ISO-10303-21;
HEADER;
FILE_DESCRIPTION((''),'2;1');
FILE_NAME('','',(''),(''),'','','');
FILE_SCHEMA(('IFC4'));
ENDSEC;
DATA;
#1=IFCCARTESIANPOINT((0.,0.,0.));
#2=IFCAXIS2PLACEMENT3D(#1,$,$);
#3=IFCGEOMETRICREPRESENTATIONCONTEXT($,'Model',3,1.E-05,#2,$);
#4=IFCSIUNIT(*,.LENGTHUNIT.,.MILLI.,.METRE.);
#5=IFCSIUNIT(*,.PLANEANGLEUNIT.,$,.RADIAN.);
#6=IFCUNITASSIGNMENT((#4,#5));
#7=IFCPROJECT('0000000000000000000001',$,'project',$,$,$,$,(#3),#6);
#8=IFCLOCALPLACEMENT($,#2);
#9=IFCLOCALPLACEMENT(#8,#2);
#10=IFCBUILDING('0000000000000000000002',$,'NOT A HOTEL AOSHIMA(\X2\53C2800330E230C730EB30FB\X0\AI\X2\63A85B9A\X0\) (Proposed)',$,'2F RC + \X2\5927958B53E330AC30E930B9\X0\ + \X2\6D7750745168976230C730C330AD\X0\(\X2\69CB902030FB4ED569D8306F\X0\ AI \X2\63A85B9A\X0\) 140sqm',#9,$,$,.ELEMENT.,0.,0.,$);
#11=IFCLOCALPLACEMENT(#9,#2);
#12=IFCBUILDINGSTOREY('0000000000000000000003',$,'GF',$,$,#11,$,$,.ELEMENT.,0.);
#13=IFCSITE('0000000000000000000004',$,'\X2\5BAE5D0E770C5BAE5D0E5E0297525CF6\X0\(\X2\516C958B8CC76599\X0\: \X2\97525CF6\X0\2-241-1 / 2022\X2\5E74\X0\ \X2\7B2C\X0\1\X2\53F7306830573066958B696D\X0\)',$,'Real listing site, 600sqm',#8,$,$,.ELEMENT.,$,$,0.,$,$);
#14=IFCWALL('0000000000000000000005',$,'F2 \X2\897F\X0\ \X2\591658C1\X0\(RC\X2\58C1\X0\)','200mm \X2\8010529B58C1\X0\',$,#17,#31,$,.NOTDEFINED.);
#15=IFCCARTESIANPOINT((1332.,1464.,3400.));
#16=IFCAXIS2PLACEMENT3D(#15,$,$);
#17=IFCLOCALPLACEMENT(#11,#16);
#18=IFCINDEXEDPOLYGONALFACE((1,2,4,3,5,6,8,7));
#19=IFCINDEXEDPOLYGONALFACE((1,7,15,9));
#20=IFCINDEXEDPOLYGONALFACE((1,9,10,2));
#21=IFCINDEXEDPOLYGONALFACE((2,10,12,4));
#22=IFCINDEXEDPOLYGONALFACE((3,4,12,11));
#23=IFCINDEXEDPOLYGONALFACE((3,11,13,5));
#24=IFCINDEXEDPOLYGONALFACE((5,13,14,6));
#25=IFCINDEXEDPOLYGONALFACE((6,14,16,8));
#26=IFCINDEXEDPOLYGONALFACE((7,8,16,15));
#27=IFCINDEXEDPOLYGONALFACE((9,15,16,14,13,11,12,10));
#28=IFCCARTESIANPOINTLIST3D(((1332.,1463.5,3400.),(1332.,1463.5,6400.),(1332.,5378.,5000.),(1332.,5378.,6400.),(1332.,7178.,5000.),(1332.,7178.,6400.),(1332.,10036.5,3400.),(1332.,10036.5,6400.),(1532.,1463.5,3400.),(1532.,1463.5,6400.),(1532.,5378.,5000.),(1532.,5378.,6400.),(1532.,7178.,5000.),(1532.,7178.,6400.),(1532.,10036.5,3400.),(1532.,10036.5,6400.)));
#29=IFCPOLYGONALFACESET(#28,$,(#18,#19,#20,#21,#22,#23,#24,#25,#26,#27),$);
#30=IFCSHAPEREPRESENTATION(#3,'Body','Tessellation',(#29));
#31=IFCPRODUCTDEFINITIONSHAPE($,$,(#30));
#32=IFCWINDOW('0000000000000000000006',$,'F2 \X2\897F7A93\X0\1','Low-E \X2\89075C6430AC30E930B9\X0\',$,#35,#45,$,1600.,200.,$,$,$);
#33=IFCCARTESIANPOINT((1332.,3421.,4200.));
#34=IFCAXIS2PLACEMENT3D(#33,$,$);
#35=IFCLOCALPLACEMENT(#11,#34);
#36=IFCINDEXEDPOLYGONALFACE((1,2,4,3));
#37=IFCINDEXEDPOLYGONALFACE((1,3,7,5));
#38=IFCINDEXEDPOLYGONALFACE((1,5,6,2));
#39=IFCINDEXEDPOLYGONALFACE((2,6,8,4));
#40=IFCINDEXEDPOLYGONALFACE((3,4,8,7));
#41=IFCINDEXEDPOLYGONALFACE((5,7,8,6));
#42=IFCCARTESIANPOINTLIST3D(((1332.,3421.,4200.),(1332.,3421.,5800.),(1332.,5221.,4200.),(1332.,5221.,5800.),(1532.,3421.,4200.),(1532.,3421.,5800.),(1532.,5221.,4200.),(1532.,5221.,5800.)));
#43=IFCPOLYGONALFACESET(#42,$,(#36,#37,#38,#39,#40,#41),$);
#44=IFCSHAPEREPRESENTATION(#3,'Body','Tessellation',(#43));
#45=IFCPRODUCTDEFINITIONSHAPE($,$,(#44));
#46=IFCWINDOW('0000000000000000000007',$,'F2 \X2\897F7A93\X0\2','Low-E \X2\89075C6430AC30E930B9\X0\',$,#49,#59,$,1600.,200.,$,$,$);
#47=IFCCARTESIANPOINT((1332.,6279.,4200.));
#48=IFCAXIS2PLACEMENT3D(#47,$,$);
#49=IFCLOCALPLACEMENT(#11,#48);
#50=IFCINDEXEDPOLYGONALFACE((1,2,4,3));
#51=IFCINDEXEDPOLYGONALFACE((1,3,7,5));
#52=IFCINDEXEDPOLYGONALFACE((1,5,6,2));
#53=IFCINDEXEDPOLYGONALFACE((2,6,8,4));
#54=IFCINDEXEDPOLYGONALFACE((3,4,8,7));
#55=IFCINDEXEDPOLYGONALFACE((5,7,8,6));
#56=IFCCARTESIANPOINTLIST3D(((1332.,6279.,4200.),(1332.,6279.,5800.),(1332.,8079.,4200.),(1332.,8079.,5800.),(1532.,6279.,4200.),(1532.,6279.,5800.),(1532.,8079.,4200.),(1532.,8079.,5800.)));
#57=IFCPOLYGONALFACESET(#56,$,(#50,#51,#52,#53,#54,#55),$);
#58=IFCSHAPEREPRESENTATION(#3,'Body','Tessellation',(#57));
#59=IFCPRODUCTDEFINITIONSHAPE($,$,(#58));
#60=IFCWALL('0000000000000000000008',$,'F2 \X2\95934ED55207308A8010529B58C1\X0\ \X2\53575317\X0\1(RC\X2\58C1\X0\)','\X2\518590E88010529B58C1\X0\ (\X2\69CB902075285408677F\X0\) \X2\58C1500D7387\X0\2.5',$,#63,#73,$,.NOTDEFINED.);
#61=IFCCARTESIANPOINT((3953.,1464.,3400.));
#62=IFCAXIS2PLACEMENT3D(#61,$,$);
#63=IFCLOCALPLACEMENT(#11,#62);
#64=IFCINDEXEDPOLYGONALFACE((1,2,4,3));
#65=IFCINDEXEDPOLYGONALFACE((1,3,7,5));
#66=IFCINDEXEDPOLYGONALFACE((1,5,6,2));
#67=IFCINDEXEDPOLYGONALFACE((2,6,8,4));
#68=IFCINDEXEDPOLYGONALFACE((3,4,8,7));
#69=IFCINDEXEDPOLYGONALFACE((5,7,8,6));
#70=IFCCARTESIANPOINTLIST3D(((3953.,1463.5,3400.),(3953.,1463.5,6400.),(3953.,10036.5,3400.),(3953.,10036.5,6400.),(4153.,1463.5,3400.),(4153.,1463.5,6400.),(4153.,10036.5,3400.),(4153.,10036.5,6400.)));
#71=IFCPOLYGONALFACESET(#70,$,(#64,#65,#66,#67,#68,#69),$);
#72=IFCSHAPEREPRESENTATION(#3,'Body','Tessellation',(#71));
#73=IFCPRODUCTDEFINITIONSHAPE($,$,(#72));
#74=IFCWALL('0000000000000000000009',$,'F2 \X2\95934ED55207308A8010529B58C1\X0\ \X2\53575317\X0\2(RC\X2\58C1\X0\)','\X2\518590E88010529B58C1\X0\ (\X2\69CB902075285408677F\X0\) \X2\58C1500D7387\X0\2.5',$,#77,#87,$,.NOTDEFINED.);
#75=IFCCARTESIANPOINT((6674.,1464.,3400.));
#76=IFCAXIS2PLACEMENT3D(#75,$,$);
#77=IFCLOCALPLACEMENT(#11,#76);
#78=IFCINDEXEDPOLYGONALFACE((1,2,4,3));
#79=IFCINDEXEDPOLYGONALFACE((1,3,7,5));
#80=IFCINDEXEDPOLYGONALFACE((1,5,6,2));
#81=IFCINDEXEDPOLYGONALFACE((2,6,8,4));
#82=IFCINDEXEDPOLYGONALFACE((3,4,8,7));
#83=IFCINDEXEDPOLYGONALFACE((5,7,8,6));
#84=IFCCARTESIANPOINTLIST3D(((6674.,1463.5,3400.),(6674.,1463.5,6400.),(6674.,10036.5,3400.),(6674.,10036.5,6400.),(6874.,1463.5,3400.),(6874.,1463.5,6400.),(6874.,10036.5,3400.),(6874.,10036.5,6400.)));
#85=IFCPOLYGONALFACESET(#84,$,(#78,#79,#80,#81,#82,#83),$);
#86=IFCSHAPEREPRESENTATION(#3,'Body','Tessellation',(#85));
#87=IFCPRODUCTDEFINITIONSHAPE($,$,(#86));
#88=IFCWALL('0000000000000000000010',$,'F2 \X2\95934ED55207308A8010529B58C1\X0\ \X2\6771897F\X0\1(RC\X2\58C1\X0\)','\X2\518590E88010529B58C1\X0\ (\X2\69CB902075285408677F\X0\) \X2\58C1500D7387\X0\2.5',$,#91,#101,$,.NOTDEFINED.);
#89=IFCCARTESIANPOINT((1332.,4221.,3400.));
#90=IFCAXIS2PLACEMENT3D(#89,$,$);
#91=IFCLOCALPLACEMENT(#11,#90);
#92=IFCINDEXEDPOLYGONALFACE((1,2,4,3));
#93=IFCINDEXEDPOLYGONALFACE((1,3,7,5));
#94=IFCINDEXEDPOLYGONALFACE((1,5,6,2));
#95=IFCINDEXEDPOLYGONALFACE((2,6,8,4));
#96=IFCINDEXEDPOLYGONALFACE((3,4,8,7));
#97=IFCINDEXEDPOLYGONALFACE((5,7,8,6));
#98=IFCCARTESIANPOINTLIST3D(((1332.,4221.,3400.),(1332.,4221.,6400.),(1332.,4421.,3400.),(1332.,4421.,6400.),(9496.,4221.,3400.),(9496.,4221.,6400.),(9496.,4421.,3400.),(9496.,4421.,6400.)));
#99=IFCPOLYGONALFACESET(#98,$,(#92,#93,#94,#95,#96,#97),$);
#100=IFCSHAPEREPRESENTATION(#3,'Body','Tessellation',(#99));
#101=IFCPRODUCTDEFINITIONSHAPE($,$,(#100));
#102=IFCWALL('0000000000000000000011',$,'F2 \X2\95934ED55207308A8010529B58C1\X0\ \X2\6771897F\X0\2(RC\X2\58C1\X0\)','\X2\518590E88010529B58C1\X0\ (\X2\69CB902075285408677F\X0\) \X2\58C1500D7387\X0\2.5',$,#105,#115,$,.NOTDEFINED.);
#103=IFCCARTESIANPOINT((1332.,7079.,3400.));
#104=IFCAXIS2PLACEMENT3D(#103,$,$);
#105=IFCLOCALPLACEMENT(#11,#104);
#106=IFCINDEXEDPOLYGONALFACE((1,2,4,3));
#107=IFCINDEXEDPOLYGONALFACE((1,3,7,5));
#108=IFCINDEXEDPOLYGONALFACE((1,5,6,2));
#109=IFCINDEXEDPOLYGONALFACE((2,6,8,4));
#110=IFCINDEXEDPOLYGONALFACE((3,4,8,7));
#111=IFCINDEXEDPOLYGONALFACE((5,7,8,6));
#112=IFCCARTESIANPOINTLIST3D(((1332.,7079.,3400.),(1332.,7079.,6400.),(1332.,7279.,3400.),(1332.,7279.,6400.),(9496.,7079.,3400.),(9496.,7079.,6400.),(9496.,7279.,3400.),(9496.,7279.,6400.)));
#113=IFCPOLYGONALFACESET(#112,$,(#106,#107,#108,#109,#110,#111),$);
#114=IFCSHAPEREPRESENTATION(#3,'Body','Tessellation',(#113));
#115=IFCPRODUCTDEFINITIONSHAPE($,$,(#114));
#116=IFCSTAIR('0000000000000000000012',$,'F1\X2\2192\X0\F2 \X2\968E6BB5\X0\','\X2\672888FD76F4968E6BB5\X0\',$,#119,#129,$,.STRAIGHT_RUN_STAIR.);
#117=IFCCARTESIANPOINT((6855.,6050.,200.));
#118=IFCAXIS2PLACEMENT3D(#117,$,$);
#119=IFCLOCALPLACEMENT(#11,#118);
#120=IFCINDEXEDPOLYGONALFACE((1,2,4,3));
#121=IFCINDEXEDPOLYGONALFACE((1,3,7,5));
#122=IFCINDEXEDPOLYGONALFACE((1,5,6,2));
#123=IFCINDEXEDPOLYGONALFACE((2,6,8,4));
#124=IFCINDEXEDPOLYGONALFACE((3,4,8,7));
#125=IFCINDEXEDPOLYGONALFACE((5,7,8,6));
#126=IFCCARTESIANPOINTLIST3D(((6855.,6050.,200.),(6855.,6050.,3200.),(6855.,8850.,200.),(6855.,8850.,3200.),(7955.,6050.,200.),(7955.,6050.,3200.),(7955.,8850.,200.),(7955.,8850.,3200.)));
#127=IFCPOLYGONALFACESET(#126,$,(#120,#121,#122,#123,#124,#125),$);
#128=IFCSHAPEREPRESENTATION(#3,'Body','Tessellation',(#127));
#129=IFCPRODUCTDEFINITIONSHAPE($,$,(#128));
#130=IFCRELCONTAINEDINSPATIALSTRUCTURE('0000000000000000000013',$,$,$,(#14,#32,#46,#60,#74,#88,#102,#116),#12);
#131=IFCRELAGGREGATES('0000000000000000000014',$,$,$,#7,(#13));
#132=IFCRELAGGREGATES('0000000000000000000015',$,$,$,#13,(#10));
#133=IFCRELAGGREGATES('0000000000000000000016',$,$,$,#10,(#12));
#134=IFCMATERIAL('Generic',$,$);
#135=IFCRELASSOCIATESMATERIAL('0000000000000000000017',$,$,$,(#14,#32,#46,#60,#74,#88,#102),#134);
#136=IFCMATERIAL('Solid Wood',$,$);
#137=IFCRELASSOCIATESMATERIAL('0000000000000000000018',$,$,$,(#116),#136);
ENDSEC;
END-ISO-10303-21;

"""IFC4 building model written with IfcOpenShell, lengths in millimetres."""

from ifc_helpers import new_model, si_unit, frame, frame_2d, origin, place, context, project, spatial, rectangle, extrude, material, element, fill, save


model = new_model("IFC4")

# Units and contexts
model_context = context("Model", 3, precision=1e-05, world=origin())
ifc_project = project(units=[si_unit("LENGTHUNIT", "METRE", prefix="MILLI"), si_unit("PLANEANGLEUNIT", "RADIAN")], contexts=[model_context])

# Site, building, storey
site_placement = place(None, origin())
site = spatial("IfcSite", under=ifc_project, at=site_placement, Name="宮崎県宮崎市青島(公開資料: 青島2-241-1 / 2022年 第1号として開業)", ObjectType="Real listing site, 600sqm", CompositionType="ELEMENT", RefElevation=0.0)
building_placement = place(site_placement, origin())
building = spatial("IfcBuilding", under=site, at=building_placement, Name="NOT A HOTEL AOSHIMA(参考モデル・AI推定) (Proposed)", ObjectType="2F RC + 大開口ガラス + 海側全面デッキ(構造・仕様は AI 推定) 140sqm", CompositionType="ELEMENT", ElevationOfRefHeight=0.0, ElevationOfTerrain=0.0)
storey_placement = place(building_placement, origin())
storey = spatial("IfcBuildingStorey", under=building, at=storey_placement, Name="GF", CompositionType="ELEMENT", Elevation=0.0)

# Shared definitions
ifc_material_1 = material(Name="Generic")

# Wall, openings, windows
wall_1_placement = place(storey_placement, frame((1332.0, 1464.0, 3400.0)))
wall_1 = element("IfcWall", 1, at=wall_1_placement, inside=storey, material=ifc_material_1, Name="F2 西 外壁(RC壁)", Description="200mm 耐力壁", PredefinedType="NOTDEFINED", context=model_context, shape_type="SweptSolid", body=[
    extrude(rectangle(XDim=200.0, YDim=8573.0, at=frame_2d((100.0, 4286.0))), frame((1332.0, 1464.0, 3400.0)), (0.0, 0.0, 1.0), 3000.0),
])
opening_1_placement = place(storey_placement, frame((1332.0, 3421.0, 4200.0)))
opening_1 = element("IfcOpeningElement", 2, at=opening_1_placement, cuts=wall_1, PredefinedType="NOTDEFINED", context=model_context, shape_type="SweptSolid", body=[
    extrude(rectangle(XDim=200.0, YDim=1800.0, at=frame_2d((100.0, 900.0))), frame((1332.0, 3421.0, 4200.0)), (0.0, 0.0, 1.0), 1600.0),
])
opening_2_placement = place(storey_placement, frame((1332.0, 6279.0, 4200.0)))
opening_2 = element("IfcOpeningElement", 3, at=opening_2_placement, cuts=wall_1, PredefinedType="NOTDEFINED", context=model_context, shape_type="SweptSolid", body=[
    extrude(rectangle(XDim=200.0, YDim=1800.0, at=frame_2d((100.0, 900.0))), frame((1332.0, 6279.0, 4200.0)), (0.0, 0.0, 1.0), 1600.0),
])
window_1_placement = place(storey_placement, frame((1332.0, 3421.0, 4200.0)))
window_1 = element("IfcWindow", 4, at=window_1_placement, inside=storey, material=ifc_material_1, Name="F2 西窓1", Description="Low-E 複層ガラス", OverallHeight=1600.0, OverallWidth=200.0, context=model_context, shape_type="SweptSolid", body=[
    extrude(rectangle(XDim=200.0, YDim=1800.0, at=frame_2d((100.0, 900.0))), frame((1332.0, 3421.0, 4200.0)), (0.0, 0.0, 1.0), 1600.0),
])
fill(opening_1, window_1)
window_2_placement = place(storey_placement, frame((1332.0, 6279.0, 4200.0)))
window_2 = element("IfcWindow", 5, at=window_2_placement, inside=storey, material=ifc_material_1, Name="F2 西窓2", Description="Low-E 複層ガラス", OverallHeight=1600.0, OverallWidth=200.0, context=model_context, shape_type="SweptSolid", body=[
    extrude(rectangle(XDim=200.0, YDim=1800.0, at=frame_2d((100.0, 900.0))), frame((1332.0, 6279.0, 4200.0)), (0.0, 0.0, 1.0), 1600.0),
])
fill(opening_2, window_2)

# Walls
wall_2_placement = place(storey_placement, frame((3953.0, 1464.0, 3400.0)))
element("IfcWall", 6, at=wall_2_placement, inside=storey, material=ifc_material_1, Name="F2 間仕切り耐力壁 南北1(RC壁)", Description="内部耐力壁 (構造用合板) 壁倍率2.5", PredefinedType="NOTDEFINED", context=model_context, shape_type="SweptSolid", body=[
    extrude(rectangle(XDim=200.0, YDim=8573.0, at=frame_2d((100.0, 4286.0))), frame((3953.0, 1464.0, 3400.0)), (0.0, 0.0, 1.0), 3000.0),
])
wall_3_placement = place(storey_placement, frame((6674.0, 1464.0, 3400.0)))
element("IfcWall", 7, at=wall_3_placement, inside=storey, material=ifc_material_1, Name="F2 間仕切り耐力壁 南北2(RC壁)", Description="内部耐力壁 (構造用合板) 壁倍率2.5", PredefinedType="NOTDEFINED", context=model_context, shape_type="SweptSolid", body=[
    extrude(rectangle(XDim=200.0, YDim=8573.0, at=frame_2d((100.0, 4286.0))), frame((6674.0, 1464.0, 3400.0)), (0.0, 0.0, 1.0), 3000.0),
])
wall_4_placement = place(storey_placement, frame((1332.0, 4221.0, 3400.0)))
element("IfcWall", 8, at=wall_4_placement, inside=storey, material=ifc_material_1, Name="F2 間仕切り耐力壁 東西1(RC壁)", Description="内部耐力壁 (構造用合板) 壁倍率2.5", PredefinedType="NOTDEFINED", context=model_context, shape_type="SweptSolid", body=[
    extrude(rectangle(XDim=8164.0, YDim=200.0, at=frame_2d((4082.0, 100.0))), frame((1332.0, 4221.0, 3400.0)), (0.0, 0.0, 1.0), 3000.0),
])
wall_5_placement = place(storey_placement, frame((1332.0, 7079.0, 3400.0)))
element("IfcWall", 9, at=wall_5_placement, inside=storey, material=ifc_material_1, Name="F2 間仕切り耐力壁 東西2(RC壁)", Description="内部耐力壁 (構造用合板) 壁倍率2.5", PredefinedType="NOTDEFINED", context=model_context, shape_type="SweptSolid", body=[
    extrude(rectangle(XDim=8164.0, YDim=200.0, at=frame_2d((4082.0, 100.0))), frame((1332.0, 7079.0, 3400.0)), (0.0, 0.0, 1.0), 3000.0),
])

# Stair
ifc_material_2 = material(Name="Solid Wood")
stair_placement = place(storey_placement, frame((6855.0, 6050.0, 200.0)))
element("IfcStair", 10, at=stair_placement, inside=storey, material=ifc_material_2, Name="F1→F2 階段", Description="木製直階段", PredefinedType="STRAIGHT_RUN_STAIR", context=model_context, shape_type="SweptSolid", body=[
    extrude(rectangle(XDim=1100.0, YDim=2800.0, at=frame_2d((550.0, 1400.0))), frame((6855.0, 6050.0, 200.0)), (0.0, 0.0, 1.0), 3000.0),
])

save(model, "model.ifc")
